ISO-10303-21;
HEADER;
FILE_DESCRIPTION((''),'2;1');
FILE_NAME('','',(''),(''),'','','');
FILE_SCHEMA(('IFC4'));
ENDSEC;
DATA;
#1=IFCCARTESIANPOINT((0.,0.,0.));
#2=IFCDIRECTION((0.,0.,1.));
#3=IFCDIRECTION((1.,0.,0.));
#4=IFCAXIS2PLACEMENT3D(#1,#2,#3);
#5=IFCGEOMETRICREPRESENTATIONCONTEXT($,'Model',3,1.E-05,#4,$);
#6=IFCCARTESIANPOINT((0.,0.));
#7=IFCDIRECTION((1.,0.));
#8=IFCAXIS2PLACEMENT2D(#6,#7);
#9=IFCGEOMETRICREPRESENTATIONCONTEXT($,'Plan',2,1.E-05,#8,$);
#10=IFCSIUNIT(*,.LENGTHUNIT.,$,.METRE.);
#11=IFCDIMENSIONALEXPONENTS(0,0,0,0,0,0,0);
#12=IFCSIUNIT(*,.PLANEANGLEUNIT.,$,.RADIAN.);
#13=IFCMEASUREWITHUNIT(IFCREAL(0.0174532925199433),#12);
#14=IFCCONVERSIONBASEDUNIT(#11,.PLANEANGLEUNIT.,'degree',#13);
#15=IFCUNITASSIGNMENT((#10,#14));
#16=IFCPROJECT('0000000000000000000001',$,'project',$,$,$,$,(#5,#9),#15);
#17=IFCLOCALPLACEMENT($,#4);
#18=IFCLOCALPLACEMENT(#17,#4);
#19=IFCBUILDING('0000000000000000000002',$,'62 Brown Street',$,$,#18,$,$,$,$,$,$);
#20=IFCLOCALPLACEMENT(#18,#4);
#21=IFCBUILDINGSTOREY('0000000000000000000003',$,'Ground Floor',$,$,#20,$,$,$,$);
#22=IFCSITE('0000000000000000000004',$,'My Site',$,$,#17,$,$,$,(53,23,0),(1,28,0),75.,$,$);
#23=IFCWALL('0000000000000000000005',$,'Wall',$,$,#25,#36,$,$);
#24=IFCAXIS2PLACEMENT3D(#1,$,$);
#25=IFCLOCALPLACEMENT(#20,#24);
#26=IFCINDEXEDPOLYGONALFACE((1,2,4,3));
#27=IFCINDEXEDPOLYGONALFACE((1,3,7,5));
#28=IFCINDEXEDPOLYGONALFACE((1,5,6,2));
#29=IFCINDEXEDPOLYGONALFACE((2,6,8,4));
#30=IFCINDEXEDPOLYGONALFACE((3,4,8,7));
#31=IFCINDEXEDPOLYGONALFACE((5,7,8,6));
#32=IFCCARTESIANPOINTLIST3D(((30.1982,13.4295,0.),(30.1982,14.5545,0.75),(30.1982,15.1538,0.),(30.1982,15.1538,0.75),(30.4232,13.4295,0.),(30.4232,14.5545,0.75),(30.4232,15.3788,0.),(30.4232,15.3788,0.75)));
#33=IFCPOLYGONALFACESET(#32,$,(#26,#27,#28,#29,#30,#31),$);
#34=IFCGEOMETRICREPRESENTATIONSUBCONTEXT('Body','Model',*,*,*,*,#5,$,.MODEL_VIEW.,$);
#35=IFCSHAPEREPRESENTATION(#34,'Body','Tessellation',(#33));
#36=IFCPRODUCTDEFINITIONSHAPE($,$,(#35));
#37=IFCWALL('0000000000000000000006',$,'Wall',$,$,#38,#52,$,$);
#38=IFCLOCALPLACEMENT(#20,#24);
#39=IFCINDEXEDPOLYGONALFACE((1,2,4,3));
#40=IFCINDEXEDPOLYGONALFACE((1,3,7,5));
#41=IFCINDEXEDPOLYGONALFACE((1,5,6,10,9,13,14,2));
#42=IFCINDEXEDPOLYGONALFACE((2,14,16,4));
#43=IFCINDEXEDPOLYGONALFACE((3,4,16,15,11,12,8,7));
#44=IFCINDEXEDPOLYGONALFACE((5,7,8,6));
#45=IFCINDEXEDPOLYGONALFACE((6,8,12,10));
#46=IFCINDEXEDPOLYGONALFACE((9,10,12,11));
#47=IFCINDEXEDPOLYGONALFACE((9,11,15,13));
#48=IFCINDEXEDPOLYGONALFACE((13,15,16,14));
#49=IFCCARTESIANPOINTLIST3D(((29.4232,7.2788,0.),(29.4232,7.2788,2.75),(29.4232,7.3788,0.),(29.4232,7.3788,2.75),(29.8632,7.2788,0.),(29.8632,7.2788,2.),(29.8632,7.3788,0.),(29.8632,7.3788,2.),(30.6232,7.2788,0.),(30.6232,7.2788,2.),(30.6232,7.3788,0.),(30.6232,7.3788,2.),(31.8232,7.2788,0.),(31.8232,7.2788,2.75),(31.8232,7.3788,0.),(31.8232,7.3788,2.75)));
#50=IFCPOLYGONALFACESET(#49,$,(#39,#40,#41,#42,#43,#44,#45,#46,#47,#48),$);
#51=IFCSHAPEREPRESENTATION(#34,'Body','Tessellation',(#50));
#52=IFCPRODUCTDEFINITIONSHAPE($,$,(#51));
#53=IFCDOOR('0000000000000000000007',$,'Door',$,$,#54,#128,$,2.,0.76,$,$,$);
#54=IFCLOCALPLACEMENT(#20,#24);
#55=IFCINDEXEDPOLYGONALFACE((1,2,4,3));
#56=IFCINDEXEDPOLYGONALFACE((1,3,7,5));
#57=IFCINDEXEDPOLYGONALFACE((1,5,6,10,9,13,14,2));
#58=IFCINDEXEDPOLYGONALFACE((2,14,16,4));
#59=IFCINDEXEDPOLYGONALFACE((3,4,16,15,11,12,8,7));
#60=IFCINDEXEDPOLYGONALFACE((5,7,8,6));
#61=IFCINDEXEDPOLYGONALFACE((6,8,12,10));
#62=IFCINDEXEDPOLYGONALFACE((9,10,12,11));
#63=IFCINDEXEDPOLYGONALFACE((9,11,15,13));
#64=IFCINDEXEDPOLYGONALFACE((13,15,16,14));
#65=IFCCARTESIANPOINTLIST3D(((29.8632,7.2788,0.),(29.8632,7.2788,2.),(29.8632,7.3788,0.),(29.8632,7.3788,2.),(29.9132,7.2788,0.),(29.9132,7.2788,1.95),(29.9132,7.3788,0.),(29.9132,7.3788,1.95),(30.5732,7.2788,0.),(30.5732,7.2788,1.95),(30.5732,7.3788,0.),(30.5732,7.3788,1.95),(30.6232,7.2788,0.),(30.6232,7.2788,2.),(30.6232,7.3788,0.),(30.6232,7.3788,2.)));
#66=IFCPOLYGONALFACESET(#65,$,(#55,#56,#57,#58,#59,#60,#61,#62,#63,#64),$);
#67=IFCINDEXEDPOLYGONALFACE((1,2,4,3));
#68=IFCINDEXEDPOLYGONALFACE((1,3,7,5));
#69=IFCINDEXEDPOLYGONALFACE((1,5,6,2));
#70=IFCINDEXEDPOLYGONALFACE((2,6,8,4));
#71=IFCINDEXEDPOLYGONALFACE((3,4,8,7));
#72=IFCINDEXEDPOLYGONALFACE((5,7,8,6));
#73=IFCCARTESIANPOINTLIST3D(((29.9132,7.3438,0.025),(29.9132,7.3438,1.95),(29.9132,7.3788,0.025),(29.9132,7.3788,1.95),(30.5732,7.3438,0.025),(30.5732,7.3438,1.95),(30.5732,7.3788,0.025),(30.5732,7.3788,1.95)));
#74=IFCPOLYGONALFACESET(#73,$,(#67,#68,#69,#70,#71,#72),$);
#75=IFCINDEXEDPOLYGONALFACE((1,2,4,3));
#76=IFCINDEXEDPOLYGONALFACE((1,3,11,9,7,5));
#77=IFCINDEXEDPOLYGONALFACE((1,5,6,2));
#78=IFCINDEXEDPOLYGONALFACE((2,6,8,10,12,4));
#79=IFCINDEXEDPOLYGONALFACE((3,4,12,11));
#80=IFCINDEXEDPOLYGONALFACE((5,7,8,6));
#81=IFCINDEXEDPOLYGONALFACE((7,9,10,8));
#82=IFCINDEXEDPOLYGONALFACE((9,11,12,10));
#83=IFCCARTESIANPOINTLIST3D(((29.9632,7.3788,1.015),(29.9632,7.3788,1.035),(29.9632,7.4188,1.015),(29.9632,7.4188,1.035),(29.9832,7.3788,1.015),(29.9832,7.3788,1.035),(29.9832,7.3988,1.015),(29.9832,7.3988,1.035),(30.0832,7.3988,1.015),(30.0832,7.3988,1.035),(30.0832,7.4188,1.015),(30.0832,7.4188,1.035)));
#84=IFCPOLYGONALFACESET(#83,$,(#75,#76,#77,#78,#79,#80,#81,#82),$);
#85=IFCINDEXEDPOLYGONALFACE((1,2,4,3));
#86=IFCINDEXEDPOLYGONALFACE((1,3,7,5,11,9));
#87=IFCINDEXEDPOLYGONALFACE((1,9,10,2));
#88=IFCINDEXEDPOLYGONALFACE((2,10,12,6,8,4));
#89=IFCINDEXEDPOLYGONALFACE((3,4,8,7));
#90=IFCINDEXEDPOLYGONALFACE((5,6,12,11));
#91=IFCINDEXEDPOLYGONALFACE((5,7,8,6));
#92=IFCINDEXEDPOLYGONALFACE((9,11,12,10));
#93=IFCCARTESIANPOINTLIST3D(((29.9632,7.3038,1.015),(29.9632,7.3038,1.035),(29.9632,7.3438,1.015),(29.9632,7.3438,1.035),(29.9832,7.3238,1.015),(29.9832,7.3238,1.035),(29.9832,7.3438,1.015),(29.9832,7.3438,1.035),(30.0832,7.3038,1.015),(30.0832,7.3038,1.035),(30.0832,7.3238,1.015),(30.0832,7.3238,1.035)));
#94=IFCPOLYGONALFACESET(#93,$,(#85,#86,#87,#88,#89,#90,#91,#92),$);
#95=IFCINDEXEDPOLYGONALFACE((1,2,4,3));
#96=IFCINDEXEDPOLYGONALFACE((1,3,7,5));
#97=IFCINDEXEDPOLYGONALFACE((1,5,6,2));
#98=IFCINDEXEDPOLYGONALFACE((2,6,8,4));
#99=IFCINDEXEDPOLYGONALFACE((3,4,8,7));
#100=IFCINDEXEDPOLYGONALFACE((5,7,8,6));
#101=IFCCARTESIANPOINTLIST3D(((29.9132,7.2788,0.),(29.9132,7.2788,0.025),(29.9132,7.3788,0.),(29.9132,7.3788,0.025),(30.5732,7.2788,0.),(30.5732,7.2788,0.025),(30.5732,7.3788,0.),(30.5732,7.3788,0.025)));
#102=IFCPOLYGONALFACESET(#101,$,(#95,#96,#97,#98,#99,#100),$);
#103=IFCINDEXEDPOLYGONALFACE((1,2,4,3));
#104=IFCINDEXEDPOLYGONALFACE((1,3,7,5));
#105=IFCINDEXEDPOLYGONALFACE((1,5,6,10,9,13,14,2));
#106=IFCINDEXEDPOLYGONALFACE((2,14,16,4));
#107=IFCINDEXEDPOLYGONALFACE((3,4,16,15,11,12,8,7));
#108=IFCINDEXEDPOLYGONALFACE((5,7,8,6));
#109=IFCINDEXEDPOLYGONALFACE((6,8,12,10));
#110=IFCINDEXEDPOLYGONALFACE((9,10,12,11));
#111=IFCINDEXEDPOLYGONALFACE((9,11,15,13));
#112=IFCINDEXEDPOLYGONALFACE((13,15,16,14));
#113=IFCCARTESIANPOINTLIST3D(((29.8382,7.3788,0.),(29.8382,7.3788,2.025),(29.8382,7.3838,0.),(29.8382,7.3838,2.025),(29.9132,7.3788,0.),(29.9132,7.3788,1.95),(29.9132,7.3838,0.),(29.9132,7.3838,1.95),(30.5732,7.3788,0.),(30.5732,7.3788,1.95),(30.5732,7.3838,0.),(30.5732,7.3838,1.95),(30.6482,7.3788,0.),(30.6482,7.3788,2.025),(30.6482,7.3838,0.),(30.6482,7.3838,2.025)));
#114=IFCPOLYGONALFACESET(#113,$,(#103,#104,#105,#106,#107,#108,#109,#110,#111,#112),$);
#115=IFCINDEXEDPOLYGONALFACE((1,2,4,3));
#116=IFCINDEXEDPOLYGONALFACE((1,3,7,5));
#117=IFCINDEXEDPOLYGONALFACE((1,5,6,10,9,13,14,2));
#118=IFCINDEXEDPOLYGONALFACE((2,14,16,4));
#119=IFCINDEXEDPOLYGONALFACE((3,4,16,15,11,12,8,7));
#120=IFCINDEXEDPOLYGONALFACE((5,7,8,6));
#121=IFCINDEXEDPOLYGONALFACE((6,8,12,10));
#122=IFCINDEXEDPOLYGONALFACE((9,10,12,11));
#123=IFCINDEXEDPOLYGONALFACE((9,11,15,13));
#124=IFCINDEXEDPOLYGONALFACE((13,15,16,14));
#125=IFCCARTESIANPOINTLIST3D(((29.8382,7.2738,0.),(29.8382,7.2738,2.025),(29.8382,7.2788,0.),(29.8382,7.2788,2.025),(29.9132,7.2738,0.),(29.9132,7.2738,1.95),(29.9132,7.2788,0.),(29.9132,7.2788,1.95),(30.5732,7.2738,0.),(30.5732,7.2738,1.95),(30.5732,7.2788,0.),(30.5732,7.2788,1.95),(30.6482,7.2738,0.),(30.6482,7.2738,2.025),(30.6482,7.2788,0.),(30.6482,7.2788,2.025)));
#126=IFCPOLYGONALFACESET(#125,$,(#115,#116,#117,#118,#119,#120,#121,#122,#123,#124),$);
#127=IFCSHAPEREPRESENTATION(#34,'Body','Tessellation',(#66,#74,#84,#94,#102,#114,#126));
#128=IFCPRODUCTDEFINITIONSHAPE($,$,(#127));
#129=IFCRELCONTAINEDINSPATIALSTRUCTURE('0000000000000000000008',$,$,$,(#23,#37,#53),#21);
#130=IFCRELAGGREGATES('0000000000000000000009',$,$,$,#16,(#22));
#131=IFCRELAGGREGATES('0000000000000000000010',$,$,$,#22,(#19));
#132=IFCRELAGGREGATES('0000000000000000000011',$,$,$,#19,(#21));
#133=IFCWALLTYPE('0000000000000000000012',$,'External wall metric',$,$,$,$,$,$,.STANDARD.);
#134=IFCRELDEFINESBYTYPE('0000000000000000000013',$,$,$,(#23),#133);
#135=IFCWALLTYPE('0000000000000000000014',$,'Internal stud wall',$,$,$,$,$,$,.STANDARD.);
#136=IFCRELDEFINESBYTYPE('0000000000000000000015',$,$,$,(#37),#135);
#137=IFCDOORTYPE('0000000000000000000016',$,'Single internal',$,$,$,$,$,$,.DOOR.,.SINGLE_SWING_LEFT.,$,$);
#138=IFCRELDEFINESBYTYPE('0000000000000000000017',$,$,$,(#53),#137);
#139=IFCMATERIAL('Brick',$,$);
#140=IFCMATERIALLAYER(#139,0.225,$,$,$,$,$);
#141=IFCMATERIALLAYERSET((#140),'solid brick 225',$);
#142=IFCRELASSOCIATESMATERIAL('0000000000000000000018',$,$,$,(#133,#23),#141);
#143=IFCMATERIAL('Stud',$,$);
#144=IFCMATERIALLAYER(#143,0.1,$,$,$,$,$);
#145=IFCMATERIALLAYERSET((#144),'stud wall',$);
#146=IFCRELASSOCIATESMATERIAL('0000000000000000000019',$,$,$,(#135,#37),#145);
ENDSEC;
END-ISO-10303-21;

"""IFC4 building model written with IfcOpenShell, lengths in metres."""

from ifc_helpers import new_model, entity, si_unit, converted_unit, frame, origin_with_axes, origin_2d_with_axis, place, context, subcontext, project, spatial, line, indexed_curve, outline, extrude, clip, halfspace, shape, source, transform, mapped, material, layer, layer_set, layer_usage, type_object, type_shapes, element, fill, save


model = new_model("IFC4")

# Units and contexts
model_context = context("Model", 3, precision=1e-05, world=origin_with_axes())
plan_context = context("Plan", 2, precision=1e-05, world=origin_2d_with_axis())
body_context_1 = subcontext(model_context, "Body", "Model", "MODEL_VIEW")
body_context_2 = subcontext(plan_context, "Body", "Plan", "PLAN_VIEW")
ifc_project = project(units=[si_unit("LENGTHUNIT", "METRE"), converted_unit("PLANEANGLEUNIT", "degree", entity("IfcReal", 0.0174532925199433), si_unit("PLANEANGLEUNIT", "RADIAN"), dimensions=[0, 0, 0, 0, 0, 0, 0])], contexts=[model_context, plan_context])

# Site, building, storey
site_placement = place(None, origin_with_axes())
site = spatial("IfcSite", under=ifc_project, at=site_placement, Name="My Site", RefLatitude=(53, 23, 0), RefLongitude=(1, 28, 0), RefElevation=75.0)
building_placement = place(site_placement, origin_with_axes())
building = spatial("IfcBuilding", under=site, at=building_placement, Name="62 Brown Street")
storey_placement = place(building_placement, origin_with_axes())
storey = spatial("IfcBuildingStorey", under=building, at=storey_placement, Name="Ground Floor")

# Shared definitions
ifc_material_1 = material(Name="Brick")
ifc_layer_1 = layer(ifc_material_1, 0.225)
ifc_layer_set_1 = layer_set([ifc_layer_1], Name="solid brick 225")
wall_type_1 = type_object("IfcWallType", Name="External wall metric", PredefinedType="STANDARD", material=ifc_layer_set_1)

# Wall
ifc_layer_usage_1 = layer_usage(ifc_layer_set_1, "AXIS2", "POSITIVE", 0.0)
wall_1_placement = place(storey_placement, frame((30.4232, 13.4295, 0.0), z_axis=(0.0, 0.0, 1.0), x_axis=(0.0, 1.0, 0.0)))
element("IfcWall", 1, at=wall_1_placement, inside=storey, type_object=wall_type_1, material=ifc_layer_usage_1, Name="Wall", context=body_context_1, shape_type="Clipping", body=[
    clip(clip(extrude(outline(indexed_curve([(0.0, 0.0), (0.0, 0.225), (1.9493, 0.225), (1.9493, 0.0), (0.0, 0.0)], self_intersect=False)), origin_with_axes(), (0.0, 0.0, 1.0), 0.75), halfspace(frame((0.416, 0.5, 0.2774), z_axis=(-0.5547, 0.0, 0.83205), x_axis=(0.0, -1.0, 0.0)), False)), halfspace(frame((1.9493, 0.0, 0.0), z_axis=(0.707107, 0.707107, 0.0), x_axis=(0.707107, -0.707107, 0.0)), False)),
])

# Wall, opening, door
ifc_material_2 = material(Name="Stud")
ifc_layer_2 = layer(ifc_material_2, 0.1)
ifc_layer_set_2 = layer_set([ifc_layer_2], Name="stud wall")
ifc_layer_usage_2 = layer_usage(ifc_layer_set_2, "AXIS2", "POSITIVE", 0.0)
wall_type_2 = type_object("IfcWallType", Name="Internal stud wall", PredefinedType="STANDARD", material=ifc_layer_set_2)
wall_2_placement = place(storey_placement, frame((31.8232, 7.3788, 0.0), z_axis=(0.0, 0.0, 1.0), x_axis=(-1.0, 0.0, 0.0)))
wall_2 = element("IfcWall", 2, at=wall_2_placement, inside=storey, type_object=wall_type_2, material=ifc_layer_usage_2, Name="Wall", context=body_context_1, shape_type="SweptSolid", body=[
    extrude(outline(indexed_curve([(0.0, 0.0), (0.0, 0.1), (2.4, 0.1), (2.4, 0.0), (0.0, 0.0)], self_intersect=False)), origin_with_axes(), (0.0, 0.0, 1.0), 2.75),
])
shared_shape_1 = source(origin_with_axes(), body_context_1, "Body", "SweptSolid", [
    extrude(outline(indexed_curve([(0.0, 0.0), (0.76, 0.0), (0.76, 2.0), (0.0, 2.0)], segments=[line(1, 2, 3, 4, 1)])), frame((0.0, -0.6, 0.0), z_axis=(0.0, -1.0, 0.0), x_axis=(1.0, 0.0, 0.0)), (0.0, 0.0, -1.0), 1.2),
])
opening_1_placement = place(wall_2_placement, frame((1.2, 0.0, 0.0), z_axis=(0.0, 0.0, 1.0), x_axis=(1.0, 0.0, 0.0)))
opening_1 = element("IfcOpeningElement", 3, at=opening_1_placement, cuts=wall_2, PredefinedType="OPENING", context=body_context_1, shape_type="MappedRepresentation", body=[
    mapped(shared_shape_1, transform((0.0, 0.0, 0.0), x_axis=(1.0, 0.0, 0.0), y_axis=(0.0, 1.0, 0.0), z_axis=(0.0, 0.0, 1.0), scale=1.0)),
])
door_type_1 = type_object("IfcDoorType", Name="Single internal", OperationType="SINGLE_SWING_LEFT", PredefinedType="DOOR")
shared_shape_2 = source(origin_with_axes(), body_context_1, "Body", "SweptSolid", [
    extrude(outline(indexed_curve([(0.0, 0.0), (0.0, 2.0), (0.76, 2.0), (0.76, 0.0), (0.71, 0.0), (0.71, 1.95), (0.05, 1.95), (0.05, 0.0)], segments=[line(1, 2, 3, 4, 5, 6, 7, 8, 1)])), frame((0.0, 0.0, 0.0), z_axis=(0.0, -1.0, 0.0), x_axis=(1.0, 0.0, 0.0)), (0.0, 0.0, -1.0), 0.1),
    extrude(outline(indexed_curve([(0.0, 0.0), (0.66, 0.0), (0.66, 0.035), (0.0, 0.035)], segments=[line(1, 2, 3, 4, 1)])), frame((0.05, 0.0, 0.025), z_axis=(0.0, 0.0, 1.0), x_axis=(1.0, 0.0, 0.0)), (0.0, 0.0, 1.0), 1.925),
    extrude(outline(indexed_curve([(0.0, 0.0), (0.0, -0.04), (-0.12, -0.04), (-0.12, -0.02), (-0.02, -0.02), (-0.02, 0.0)], segments=[line(1, 2, 3, 4, 5, 6, 1)])), frame((0.66, 0.0, 1.015), z_axis=(0.0, 0.0, 1.0), x_axis=(1.0, 0.0, 0.0)), (0.0, 0.0, 1.0), 0.02),
    extrude(outline(indexed_curve([(0.0, 0.0), (0.0, 0.04), (-0.12, 0.04), (-0.12, 0.02), (-0.02, 0.02), (-0.02, 0.0)], segments=[line(1, 2, 3, 4, 5, 6, 1)])), frame((0.66, 0.035, 1.015), z_axis=(0.0, 0.0, 1.0), x_axis=(1.0, 0.0, 0.0)), (0.0, 0.0, 1.0), 0.02),
    extrude(outline(indexed_curve([(0.0, 0.0), (0.66, 0.0), (0.66, 0.1), (0.0, 0.1)], segments=[line(1, 2, 3, 4, 1)])), frame((0.05, 0.0, 0.0), z_axis=(0.0, 0.0, 1.0), x_axis=(1.0, 0.0, 0.0)), (0.0, 0.0, 1.0), 0.025),
    extrude(outline(indexed_curve([(0.0, 0.0), (0.0, 2.025), (0.81, 2.025), (0.81, 0.0), (0.735, 0.0), (0.735, 1.95), (0.075, 1.95), (0.075, 0.0)], segments=[line(1, 2, 3, 4, 5, 6, 7, 8, 1)])), frame((-0.025, -0.005, 0.0), z_axis=(0.0, -1.0, 0.0), x_axis=(1.0, 0.0, 0.0)), (0.0, 0.0, -1.0), 0.005),
    extrude(outline(indexed_curve([(0.0, 0.0), (0.0, 2.025), (0.81, 2.025), (0.81, 0.0), (0.735, 0.0), (0.735, 1.95), (0.075, 1.95), (0.075, 0.0)], segments=[line(1, 2, 3, 4, 5, 6, 7, 8, 1)])), frame((-0.025, 0.1, 0.0), z_axis=(0.0, -1.0, 0.0), x_axis=(1.0, 0.0, 0.0)), (0.0, 0.0, -1.0), 0.005),
])
shared_shape_3 = source(origin_with_axes(), body_context_2, "Body", "Curve2D", [
    entity("IfcIndexedPolyCurve", entity("IfcCartesianPointList2D", [[0.0, 0.0], [0.05, 0.0], [0.05, 0.1], [0.0, 0.1]]), [entity("IfcLineIndex", [1, 2, 3, 4, 1])]),
    entity("IfcIndexedPolyCurve", entity("IfcCartesianPointList2D", [[0.76, 0.0], [0.71, 0.0], [0.71, 0.1], [0.76, 0.1]]), [entity("IfcLineIndex", [1, 2, 3, 4, 1])]),
    entity("IfcTrimmedCurve", entity("IfcEllipse", entity("IfcAxis2Placement2D", entity("IfcCartesianPoint", [0.085, 0.1]), entity("IfcDirection", [1.0, 0.0])), 0.625, 0.66), [entity("IfcCartesianPoint", [0.71, 0.1])], [entity("IfcCartesianPoint", [0.085, 0.76])], True, "CARTESIAN"),
    entity("IfcIndexedPolyCurve", entity("IfcCartesianPointList2D", [[0.05, 0.1], [0.085, 0.1], [0.085, 0.76], [0.05, 0.76]]), [entity("IfcLineIndex", [1, 2, 3, 4, 1])]),
])
type_shapes(door_type_1, [shared_shape_2, shared_shape_3])
door_1_placement = place(opening_1_placement, frame((0.0, 0.0, 0.0), z_axis=(0.0, 0.0, 1.0), x_axis=(1.0, 0.0, 0.0)))
door_1 = element("IfcDoor", 4, at=door_1_placement, inside=storey, type_object=door_type_1, Name="Door", OverallHeight=2.0, OverallWidth=0.76, shapes=[
    shape(body_context_1, "Body", "MappedRepresentation", [mapped(shared_shape_2, transform((0.0, 0.0, 0.0), x_axis=(1.0, 0.0, 0.0), y_axis=(0.0, 1.0, 0.0), z_axis=(0.0, 0.0, 1.0), scale=1.0))]),
    shape(body_context_2, "Body", "MappedRepresentation", [mapped(shared_shape_3, transform((0.0, 0.0, 0.0), x_axis=(1.0, 0.0, 0.0), y_axis=(0.0, 1.0, 0.0), z_axis=(0.0, 0.0, 1.0), scale=1.0))]),
])
fill(opening_1, door_1)

save(model, "model.ifc")
